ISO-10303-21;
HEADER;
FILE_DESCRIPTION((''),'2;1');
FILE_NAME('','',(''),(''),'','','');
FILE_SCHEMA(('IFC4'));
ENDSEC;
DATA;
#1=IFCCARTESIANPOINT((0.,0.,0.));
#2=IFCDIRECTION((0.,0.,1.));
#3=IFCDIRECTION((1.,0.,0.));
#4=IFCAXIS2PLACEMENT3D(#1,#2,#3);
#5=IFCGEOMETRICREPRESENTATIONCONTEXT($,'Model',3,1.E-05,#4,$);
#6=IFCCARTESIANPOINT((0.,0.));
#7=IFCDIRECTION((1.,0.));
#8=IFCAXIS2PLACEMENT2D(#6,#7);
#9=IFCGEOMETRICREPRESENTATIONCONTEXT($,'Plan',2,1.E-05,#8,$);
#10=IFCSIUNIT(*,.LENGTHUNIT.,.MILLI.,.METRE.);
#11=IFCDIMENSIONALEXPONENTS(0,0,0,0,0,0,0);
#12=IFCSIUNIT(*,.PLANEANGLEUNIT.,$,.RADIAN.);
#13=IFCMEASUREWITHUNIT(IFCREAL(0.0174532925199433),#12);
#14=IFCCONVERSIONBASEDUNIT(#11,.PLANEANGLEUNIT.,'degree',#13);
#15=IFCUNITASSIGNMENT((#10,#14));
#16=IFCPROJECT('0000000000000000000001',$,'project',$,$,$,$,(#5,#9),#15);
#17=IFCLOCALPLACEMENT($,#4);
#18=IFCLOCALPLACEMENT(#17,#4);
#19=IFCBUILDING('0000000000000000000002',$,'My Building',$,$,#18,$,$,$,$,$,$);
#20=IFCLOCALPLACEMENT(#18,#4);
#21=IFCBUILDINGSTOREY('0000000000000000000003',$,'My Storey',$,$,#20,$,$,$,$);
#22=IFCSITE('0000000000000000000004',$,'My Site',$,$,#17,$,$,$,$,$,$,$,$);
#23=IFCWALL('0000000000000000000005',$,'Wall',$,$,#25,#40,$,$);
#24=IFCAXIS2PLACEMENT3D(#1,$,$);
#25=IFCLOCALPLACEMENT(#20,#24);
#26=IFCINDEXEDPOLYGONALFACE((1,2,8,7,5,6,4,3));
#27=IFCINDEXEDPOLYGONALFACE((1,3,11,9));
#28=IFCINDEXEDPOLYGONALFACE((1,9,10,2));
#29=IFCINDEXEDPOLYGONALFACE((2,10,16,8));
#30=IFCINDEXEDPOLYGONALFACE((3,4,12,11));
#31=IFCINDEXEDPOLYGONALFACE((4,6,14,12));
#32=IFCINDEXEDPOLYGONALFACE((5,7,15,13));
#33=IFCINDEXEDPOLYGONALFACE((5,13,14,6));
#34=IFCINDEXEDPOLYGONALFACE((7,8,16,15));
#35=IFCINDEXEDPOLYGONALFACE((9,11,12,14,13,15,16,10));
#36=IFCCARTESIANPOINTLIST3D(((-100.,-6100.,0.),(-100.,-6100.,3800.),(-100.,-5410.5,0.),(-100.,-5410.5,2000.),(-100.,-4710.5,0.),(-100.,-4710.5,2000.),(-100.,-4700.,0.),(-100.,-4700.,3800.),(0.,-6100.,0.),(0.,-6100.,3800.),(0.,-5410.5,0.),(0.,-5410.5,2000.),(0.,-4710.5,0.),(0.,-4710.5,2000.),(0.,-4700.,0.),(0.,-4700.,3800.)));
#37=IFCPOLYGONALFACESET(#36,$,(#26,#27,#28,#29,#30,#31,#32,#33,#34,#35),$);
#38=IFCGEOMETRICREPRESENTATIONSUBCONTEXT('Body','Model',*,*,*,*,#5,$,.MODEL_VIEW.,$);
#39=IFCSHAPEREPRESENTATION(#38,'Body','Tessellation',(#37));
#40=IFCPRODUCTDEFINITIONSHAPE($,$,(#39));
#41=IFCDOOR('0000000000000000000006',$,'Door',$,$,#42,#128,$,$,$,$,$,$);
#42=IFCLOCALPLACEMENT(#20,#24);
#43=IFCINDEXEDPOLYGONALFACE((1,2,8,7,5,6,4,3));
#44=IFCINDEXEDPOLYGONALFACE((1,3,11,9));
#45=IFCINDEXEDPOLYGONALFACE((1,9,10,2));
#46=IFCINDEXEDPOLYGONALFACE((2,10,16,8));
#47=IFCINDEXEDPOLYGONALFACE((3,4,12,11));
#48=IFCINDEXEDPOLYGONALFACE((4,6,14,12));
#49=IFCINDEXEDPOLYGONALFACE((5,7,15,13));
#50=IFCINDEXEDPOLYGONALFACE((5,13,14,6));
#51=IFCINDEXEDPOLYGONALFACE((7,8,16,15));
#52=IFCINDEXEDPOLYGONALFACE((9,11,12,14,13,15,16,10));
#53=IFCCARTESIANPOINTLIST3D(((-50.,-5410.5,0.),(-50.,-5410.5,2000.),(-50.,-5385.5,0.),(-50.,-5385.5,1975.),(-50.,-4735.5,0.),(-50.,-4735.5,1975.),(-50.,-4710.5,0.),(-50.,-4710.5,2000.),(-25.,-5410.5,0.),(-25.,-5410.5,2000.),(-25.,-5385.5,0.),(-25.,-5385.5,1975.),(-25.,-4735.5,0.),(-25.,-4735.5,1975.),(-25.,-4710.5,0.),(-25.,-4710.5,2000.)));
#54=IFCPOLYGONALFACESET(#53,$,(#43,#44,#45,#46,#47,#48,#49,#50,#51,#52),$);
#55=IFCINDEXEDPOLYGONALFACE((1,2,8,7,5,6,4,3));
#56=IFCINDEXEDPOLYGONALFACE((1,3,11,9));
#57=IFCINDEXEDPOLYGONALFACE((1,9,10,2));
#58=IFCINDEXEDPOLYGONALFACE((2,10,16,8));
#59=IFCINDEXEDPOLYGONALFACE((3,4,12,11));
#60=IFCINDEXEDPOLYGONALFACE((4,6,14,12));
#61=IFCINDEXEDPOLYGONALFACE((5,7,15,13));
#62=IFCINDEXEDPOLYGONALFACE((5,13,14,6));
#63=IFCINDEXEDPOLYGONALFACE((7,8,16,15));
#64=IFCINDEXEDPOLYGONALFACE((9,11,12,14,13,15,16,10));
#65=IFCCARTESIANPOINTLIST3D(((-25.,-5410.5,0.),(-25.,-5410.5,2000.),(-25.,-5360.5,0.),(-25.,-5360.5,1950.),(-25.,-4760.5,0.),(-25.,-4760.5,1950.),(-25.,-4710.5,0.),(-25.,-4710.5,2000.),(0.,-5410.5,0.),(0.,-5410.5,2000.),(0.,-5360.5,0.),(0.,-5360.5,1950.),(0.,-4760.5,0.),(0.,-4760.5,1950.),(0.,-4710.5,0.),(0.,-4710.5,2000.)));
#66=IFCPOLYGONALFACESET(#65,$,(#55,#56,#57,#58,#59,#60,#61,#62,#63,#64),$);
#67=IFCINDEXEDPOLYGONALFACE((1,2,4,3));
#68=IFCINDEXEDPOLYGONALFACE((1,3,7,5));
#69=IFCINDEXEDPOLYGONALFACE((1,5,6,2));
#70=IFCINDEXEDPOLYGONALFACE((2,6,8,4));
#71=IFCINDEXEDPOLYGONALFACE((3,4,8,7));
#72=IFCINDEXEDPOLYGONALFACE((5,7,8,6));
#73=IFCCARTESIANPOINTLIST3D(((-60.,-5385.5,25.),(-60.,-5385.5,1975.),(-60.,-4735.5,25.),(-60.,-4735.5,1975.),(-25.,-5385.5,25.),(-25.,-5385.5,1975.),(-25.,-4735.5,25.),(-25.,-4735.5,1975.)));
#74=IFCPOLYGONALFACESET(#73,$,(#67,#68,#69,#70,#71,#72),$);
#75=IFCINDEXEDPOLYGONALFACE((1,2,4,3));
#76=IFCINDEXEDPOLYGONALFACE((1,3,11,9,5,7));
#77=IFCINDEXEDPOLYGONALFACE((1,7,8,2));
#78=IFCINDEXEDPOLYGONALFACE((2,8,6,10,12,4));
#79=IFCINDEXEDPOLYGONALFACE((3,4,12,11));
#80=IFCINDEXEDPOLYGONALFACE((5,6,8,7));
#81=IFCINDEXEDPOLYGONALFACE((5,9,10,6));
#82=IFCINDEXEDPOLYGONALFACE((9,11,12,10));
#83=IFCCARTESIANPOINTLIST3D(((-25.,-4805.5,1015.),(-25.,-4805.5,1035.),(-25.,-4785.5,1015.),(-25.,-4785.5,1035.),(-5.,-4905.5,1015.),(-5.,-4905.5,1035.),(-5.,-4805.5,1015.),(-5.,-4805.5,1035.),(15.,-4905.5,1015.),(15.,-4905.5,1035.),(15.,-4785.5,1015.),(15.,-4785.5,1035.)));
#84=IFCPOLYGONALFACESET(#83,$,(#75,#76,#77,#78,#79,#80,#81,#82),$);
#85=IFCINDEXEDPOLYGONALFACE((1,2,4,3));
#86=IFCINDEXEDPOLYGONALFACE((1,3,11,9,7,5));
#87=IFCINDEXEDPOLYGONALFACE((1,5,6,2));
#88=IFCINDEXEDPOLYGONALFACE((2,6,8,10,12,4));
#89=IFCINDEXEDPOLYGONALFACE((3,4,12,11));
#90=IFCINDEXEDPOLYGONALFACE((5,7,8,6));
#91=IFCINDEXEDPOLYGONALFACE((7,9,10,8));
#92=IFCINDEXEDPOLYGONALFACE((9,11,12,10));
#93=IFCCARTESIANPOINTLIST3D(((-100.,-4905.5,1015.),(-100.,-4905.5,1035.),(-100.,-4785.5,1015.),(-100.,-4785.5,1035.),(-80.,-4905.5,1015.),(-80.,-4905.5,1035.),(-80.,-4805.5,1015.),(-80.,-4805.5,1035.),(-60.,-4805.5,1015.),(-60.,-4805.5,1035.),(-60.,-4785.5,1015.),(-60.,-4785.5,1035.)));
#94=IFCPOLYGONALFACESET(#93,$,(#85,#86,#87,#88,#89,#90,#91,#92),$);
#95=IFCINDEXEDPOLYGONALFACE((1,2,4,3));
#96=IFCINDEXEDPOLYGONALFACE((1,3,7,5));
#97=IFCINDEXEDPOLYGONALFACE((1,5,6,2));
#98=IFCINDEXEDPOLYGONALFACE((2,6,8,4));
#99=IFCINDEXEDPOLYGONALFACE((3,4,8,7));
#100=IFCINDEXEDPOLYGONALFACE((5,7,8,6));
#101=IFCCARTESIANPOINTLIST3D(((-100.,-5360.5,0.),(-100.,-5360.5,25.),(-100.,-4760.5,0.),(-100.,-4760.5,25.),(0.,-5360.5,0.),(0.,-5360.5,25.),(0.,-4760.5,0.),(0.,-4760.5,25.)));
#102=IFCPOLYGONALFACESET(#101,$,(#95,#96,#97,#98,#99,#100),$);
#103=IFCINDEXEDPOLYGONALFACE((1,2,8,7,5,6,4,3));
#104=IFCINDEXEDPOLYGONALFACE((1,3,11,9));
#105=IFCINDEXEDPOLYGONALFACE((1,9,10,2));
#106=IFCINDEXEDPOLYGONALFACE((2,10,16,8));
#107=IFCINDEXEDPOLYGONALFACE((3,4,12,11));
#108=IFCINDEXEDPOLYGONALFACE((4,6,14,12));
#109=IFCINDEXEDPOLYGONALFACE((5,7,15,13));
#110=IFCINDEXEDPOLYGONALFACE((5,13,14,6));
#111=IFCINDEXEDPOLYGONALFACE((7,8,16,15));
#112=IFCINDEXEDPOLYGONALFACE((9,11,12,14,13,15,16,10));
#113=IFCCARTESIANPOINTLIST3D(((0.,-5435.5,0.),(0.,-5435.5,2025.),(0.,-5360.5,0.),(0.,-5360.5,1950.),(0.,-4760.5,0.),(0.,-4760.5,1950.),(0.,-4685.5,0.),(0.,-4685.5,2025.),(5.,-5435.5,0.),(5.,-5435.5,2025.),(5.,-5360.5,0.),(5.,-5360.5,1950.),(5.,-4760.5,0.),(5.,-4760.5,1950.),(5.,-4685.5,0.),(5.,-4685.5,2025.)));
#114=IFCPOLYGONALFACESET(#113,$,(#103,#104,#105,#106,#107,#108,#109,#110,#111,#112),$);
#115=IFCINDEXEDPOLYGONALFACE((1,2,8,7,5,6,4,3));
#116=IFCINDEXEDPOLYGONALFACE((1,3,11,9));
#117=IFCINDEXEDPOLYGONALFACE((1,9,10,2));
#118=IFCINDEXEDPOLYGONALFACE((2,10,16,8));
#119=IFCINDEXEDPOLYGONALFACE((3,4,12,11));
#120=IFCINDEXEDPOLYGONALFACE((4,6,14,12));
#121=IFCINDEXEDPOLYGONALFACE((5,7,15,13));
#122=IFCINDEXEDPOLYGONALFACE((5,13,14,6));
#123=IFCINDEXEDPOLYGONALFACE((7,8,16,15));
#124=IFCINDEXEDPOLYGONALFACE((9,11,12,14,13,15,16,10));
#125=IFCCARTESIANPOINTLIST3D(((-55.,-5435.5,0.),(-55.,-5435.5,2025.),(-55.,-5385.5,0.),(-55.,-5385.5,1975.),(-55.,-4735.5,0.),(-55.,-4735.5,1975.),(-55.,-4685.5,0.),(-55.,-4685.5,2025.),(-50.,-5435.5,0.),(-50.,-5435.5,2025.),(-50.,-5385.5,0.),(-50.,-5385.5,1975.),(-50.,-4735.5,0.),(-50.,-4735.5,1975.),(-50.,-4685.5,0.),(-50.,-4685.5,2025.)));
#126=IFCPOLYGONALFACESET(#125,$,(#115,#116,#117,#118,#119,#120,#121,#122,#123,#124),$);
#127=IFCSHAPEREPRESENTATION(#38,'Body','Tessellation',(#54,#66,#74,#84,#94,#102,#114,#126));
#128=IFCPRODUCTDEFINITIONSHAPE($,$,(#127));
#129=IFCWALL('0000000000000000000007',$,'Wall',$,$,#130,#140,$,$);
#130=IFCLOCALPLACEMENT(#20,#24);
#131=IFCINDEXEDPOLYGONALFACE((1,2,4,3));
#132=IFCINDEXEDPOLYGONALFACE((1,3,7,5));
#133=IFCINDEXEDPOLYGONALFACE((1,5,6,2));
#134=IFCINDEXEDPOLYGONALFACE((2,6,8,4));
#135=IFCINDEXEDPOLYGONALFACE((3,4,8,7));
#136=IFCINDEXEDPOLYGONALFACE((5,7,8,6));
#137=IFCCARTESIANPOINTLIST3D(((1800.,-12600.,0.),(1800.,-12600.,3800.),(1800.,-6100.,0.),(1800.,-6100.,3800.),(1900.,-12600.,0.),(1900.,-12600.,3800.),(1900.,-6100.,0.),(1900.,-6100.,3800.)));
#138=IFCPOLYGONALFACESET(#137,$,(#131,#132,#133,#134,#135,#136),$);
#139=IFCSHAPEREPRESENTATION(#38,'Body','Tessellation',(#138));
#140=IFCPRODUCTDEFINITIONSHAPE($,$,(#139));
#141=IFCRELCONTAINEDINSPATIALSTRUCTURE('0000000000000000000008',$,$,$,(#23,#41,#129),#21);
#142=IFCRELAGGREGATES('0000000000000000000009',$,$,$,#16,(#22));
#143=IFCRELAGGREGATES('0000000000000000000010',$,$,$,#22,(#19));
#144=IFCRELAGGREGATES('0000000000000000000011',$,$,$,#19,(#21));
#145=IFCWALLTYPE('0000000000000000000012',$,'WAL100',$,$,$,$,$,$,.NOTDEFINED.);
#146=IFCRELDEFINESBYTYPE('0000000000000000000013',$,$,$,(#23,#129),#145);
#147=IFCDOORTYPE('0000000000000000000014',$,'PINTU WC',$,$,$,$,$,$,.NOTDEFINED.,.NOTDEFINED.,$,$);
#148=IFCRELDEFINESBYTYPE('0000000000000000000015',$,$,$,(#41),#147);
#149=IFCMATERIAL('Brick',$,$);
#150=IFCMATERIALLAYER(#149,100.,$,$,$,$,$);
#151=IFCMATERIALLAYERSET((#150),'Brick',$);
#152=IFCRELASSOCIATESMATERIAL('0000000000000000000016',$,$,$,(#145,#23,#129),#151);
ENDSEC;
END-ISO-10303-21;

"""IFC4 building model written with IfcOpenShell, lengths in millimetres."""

from ifc_helpers import new_model, entity, si_unit, converted_unit, frame, origin_with_axes, origin_2d_with_axis, place, context, subcontext, project, spatial, line, indexed_curve, outline, extrude, shape, source, transform, mapped, material, layer, layer_set, layer_usage, type_object, type_shapes, element, fill, save


model = new_model("IFC4")

# Units and contexts
model_context = context("Model", 3, precision=1e-05, world=origin_with_axes())
plan_context = context("Plan", 2, precision=1e-05, world=origin_2d_with_axis())
body_context_1 = subcontext(model_context, "Body", "Model", "MODEL_VIEW")
body_context_2 = subcontext(plan_context, "Body", "Plan", "PLAN_VIEW")
ifc_project = project(units=[si_unit("LENGTHUNIT", "METRE", prefix="MILLI"), converted_unit("PLANEANGLEUNIT", "degree", entity("IfcReal", 0.0174532925199433), si_unit("PLANEANGLEUNIT", "RADIAN"), dimensions=[0, 0, 0, 0, 0, 0, 0])], contexts=[model_context, plan_context])

# Site, building, storey
site_placement = place(None, origin_with_axes())
site = spatial("IfcSite", under=ifc_project, at=site_placement, Name="My Site")
building_placement = place(site_placement, origin_with_axes())
building = spatial("IfcBuilding", under=site, at=building_placement, Name="My Building")
storey_placement = place(building_placement, origin_with_axes())
storey = spatial("IfcBuildingStorey", under=building, at=storey_placement, Name="My Storey")

# Wall, opening, door
ifc_material = material(Name="Brick")
ifc_layer_1 = layer(ifc_material, 100.0)
ifc_layer_set_1 = layer_set([ifc_layer_1], Name="Brick")
ifc_layer_usage_1 = layer_usage(ifc_layer_set_1, "AXIS2", "POSITIVE", 0.0)
wall_type = type_object("IfcWallType", Name="WAL100", PredefinedType="NOTDEFINED", material=ifc_layer_set_1)
wall_1_placement = place(storey_placement, frame((0.0, -6100.0, 0.0), z_axis=(0.0, 0.0, 1.0), x_axis=(0.0, 1.0, 0.0)))
wall_1 = element("IfcWall", 1, at=wall_1_placement, inside=storey, type_object=wall_type, material=ifc_layer_usage_1, Name="Wall", context=body_context_1, shape_type="SweptSolid", body=[
    extrude(outline(indexed_curve([(0.0, 0.0), (0.0, 100.0), (1400.0, 100.0), (1400.0, 0.0), (0.0, 0.0)], self_intersect=False)), origin_with_axes(), (0.0, 0.0, 1.0), 3800.0),
])
shared_shape_1 = source(origin_with_axes(), body_context_1, "Body", "SweptSolid", [
    extrude(outline(indexed_curve([(0.0, 0.0), (700.0, 0.0), (700.0, 2000.0), (0.0, 2000.0)], segments=[line(1, 2, 3, 4, 1)])), frame((0.0, -100.0, 0.0), z_axis=(0.0, -1.0, 0.0), x_axis=(1.0, 0.0, 0.0)), (0.0, 0.0, -1.0), 300.0),
])
opening_1_placement = place(wall_1_placement, frame((689.5, 0.0, 0.0), z_axis=(0.0, 0.0, 1.0), x_axis=(1.0, 0.0, 0.0)))
opening_1 = element("IfcOpeningElement", 2, at=opening_1_placement, cuts=wall_1, PredefinedType="OPENING", context=body_context_1, shape_type="MappedRepresentation", body=[
    mapped(shared_shape_1, transform((0.0, 0.0, 0.0), x_axis=(1.0, 0.0, 0.0), y_axis=(0.0, 1.0, 0.0), z_axis=(0.0, 0.0, 1.0), scale=1.0)),
])
door_type_1 = type_object("IfcDoorType", Name="PINTU WC", OperationType="NOTDEFINED", PredefinedType="NOTDEFINED")
shared_shape_2 = source(origin_with_axes(), body_context_1, "Body", "SweptSolid", [
    extrude(outline(indexed_curve([(0.0, 0.0), (0.0, 2000.0), (700.0, 2000.0), (700.0, 0.0), (675.0, 0.0), (675.0, 1975.0), (25.0, 1975.0), (25.0, 0.0)], segments=[line(1, 2, 3, 4, 5, 6, 7, 8, 1)])), frame((0.0, 25.0, 0.0), z_axis=(0.0, -1.0, 0.0), x_axis=(1.0, 0.0, 0.0)), (0.0, 0.0, -1.0), 25.0),
    extrude(outline(indexed_curve([(0.0, 0.0), (0.0, 2000.0), (700.0, 2000.0), (700.0, 0.0), (650.0, 0.0), (650.0, 1950.0), (50.0, 1950.0), (50.0, 0.0)], segments=[line(1, 2, 3, 4, 5, 6, 7, 8, 1)])), frame((0.0, 0.0, 0.0), z_axis=(0.0, -1.0, 0.0), x_axis=(1.0, 0.0, 0.0)), (0.0, 0.0, -1.0), 25.0),
    extrude(outline(indexed_curve([(0.0, 0.0), (650.0, 0.0), (650.0, 35.0), (0.0, 35.0)], segments=[line(1, 2, 3, 4, 1)])), frame((25.0, 25.0, 25.0), z_axis=(0.0, 0.0, 1.0), x_axis=(1.0, 0.0, 0.0)), (0.0, 0.0, 1.0), 1950.0),
    extrude(outline(indexed_curve([(0.0, 0.0), (0.0, -40.0), (-120.0, -40.0), (-120.0, -20.0), (-20.0, -20.0), (-20.0, 0.0)], segments=[line(1, 2, 3, 4, 5, 6, 1)])), frame((625.0, 25.0, 1015.0), z_axis=(0.0, 0.0, 1.0), x_axis=(1.0, 0.0, 0.0)), (0.0, 0.0, 1.0), 20.0),
    extrude(outline(indexed_curve([(0.0, 0.0), (0.0, 40.0), (-120.0, 40.0), (-120.0, 20.0), (-20.0, 20.0), (-20.0, 0.0)], segments=[line(1, 2, 3, 4, 5, 6, 1)])), frame((625.0, 60.0, 1015.0), z_axis=(0.0, 0.0, 1.0), x_axis=(1.0, 0.0, 0.0)), (0.0, 0.0, 1.0), 20.0),
    extrude(outline(indexed_curve([(0.0, 0.0), (600.0, 0.0), (600.0, 100.0), (0.0, 100.0)], segments=[line(1, 2, 3, 4, 1)])), frame((50.0, 0.0, 0.0), z_axis=(0.0, 0.0, 1.0), x_axis=(1.0, 0.0, 0.0)), (0.0, 0.0, 1.0), 25.0),
    extrude(outline(indexed_curve([(0.0, 0.0), (0.0, 2025.0), (750.0, 2025.0), (750.0, 0.0), (675.0, 0.0), (675.0, 1950.0), (75.0, 1950.0), (75.0, 0.0)], segments=[line(1, 2, 3, 4, 5, 6, 7, 8, 1)])), frame((-25.0, -5.0, 0.0), z_axis=(0.0, -1.0, 0.0), x_axis=(1.0, 0.0, 0.0)), (0.0, 0.0, -1.0), 5.0),
    extrude(outline(indexed_curve([(0.0, 0.0), (0.0, 2025.0), (750.0, 2025.0), (750.0, 0.0), (700.0, 0.0), (700.0, 1975.0), (50.0, 1975.0), (50.0, 0.0)], segments=[line(1, 2, 3, 4, 5, 6, 7, 8, 1)])), frame((-25.0, 50.0, 0.0), z_axis=(0.0, -1.0, 0.0), x_axis=(1.0, 0.0, 0.0)), (0.0, 0.0, -1.0), 5.0),
])
shared_shape_3 = source(origin_with_axes(), body_context_2, "Body", "Curve2D", [
    entity("IfcIndexedPolyCurve", entity("IfcCartesianPointList2D", [[0.0, 0.0], [0.0, 50.0], [25.0, 50.0], [25.0, 25.0], [50.0, 25.0], [50.0, 0.0]]), [entity("IfcLineIndex", [1, 2, 3, 4, 5, 6, 1])]),
    entity("IfcIndexedPolyCurve", entity("IfcCartesianPointList2D", [[700.0, 0.0], [700.0, 50.0], [675.0, 50.0], [675.0, 25.0], [650.0, 25.0], [650.0, 0.0]]), [entity("IfcLineIndex", [1, 2, 3, 4, 5, 6, 1])]),
    entity("IfcTrimmedCurve", entity("IfcEllipse", entity("IfcAxis2Placement2D", entity("IfcCartesianPoint", [60.0, 50.0]), entity("IfcDirection", [1.0, 0.0])), 615.0, 650.0), [entity("IfcCartesianPoint", [675.0, 50.0])], [entity("IfcCartesianPoint", [60.0, 700.0])], True, "CARTESIAN"),
    entity("IfcIndexedPolyCurve", entity("IfcCartesianPointList2D", [[25.0, 50.0], [60.0, 50.0], [60.0, 700.0], [25.0, 700.0]]), [entity("IfcLineIndex", [1, 2, 3, 4, 1])]),
])
type_shapes(door_type_1, [shared_shape_2, shared_shape_3])
door_1_placement = place(opening_1_placement, origin_with_axes())
door_1 = element("IfcDoor", 3, at=door_1_placement, inside=storey, type_object=door_type_1, Name="Door", shapes=[
    shape(body_context_1, "Body", "MappedRepresentation", [mapped(shared_shape_2, transform((0.0, 0.0, 0.0), x_axis=(1.0, 0.0, 0.0), y_axis=(0.0, 1.0, 0.0), z_axis=(0.0, 0.0, 1.0), scale=1.0))]),
    shape(body_context_2, "Body", "MappedRepresentation", [mapped(shared_shape_3, transform((0.0, 0.0, 0.0), x_axis=(1.0, 0.0, 0.0), y_axis=(0.0, 1.0, 0.0), z_axis=(0.0, 0.0, 1.0), scale=1.0))]),
])
fill(opening_1, door_1)

# Wall
ifc_layer_usage_2 = layer_usage(ifc_layer_set_1, "AXIS2", "POSITIVE", 0.0)
wall_2_placement = place(storey_placement, frame((1900.0, -12600.0, 0.0), z_axis=(0.0, 0.0, 1.0), x_axis=(0.000002, 1.0, 0.0)))
element("IfcWall", 4, at=wall_2_placement, inside=storey, type_object=wall_type, material=ifc_layer_usage_2, Name="Wall", context=body_context_1, shape_type="SweptSolid", body=[
    extrude(outline(indexed_curve([(0.0, 0.0), (0.0, 100.0), (6500.0, 100.0), (6500.0, 0.0), (0.0, 0.0)], self_intersect=False)), origin_with_axes(), (0.0, 0.0, 1.0), 3800.0),
])

save(model, "model.ifc")
